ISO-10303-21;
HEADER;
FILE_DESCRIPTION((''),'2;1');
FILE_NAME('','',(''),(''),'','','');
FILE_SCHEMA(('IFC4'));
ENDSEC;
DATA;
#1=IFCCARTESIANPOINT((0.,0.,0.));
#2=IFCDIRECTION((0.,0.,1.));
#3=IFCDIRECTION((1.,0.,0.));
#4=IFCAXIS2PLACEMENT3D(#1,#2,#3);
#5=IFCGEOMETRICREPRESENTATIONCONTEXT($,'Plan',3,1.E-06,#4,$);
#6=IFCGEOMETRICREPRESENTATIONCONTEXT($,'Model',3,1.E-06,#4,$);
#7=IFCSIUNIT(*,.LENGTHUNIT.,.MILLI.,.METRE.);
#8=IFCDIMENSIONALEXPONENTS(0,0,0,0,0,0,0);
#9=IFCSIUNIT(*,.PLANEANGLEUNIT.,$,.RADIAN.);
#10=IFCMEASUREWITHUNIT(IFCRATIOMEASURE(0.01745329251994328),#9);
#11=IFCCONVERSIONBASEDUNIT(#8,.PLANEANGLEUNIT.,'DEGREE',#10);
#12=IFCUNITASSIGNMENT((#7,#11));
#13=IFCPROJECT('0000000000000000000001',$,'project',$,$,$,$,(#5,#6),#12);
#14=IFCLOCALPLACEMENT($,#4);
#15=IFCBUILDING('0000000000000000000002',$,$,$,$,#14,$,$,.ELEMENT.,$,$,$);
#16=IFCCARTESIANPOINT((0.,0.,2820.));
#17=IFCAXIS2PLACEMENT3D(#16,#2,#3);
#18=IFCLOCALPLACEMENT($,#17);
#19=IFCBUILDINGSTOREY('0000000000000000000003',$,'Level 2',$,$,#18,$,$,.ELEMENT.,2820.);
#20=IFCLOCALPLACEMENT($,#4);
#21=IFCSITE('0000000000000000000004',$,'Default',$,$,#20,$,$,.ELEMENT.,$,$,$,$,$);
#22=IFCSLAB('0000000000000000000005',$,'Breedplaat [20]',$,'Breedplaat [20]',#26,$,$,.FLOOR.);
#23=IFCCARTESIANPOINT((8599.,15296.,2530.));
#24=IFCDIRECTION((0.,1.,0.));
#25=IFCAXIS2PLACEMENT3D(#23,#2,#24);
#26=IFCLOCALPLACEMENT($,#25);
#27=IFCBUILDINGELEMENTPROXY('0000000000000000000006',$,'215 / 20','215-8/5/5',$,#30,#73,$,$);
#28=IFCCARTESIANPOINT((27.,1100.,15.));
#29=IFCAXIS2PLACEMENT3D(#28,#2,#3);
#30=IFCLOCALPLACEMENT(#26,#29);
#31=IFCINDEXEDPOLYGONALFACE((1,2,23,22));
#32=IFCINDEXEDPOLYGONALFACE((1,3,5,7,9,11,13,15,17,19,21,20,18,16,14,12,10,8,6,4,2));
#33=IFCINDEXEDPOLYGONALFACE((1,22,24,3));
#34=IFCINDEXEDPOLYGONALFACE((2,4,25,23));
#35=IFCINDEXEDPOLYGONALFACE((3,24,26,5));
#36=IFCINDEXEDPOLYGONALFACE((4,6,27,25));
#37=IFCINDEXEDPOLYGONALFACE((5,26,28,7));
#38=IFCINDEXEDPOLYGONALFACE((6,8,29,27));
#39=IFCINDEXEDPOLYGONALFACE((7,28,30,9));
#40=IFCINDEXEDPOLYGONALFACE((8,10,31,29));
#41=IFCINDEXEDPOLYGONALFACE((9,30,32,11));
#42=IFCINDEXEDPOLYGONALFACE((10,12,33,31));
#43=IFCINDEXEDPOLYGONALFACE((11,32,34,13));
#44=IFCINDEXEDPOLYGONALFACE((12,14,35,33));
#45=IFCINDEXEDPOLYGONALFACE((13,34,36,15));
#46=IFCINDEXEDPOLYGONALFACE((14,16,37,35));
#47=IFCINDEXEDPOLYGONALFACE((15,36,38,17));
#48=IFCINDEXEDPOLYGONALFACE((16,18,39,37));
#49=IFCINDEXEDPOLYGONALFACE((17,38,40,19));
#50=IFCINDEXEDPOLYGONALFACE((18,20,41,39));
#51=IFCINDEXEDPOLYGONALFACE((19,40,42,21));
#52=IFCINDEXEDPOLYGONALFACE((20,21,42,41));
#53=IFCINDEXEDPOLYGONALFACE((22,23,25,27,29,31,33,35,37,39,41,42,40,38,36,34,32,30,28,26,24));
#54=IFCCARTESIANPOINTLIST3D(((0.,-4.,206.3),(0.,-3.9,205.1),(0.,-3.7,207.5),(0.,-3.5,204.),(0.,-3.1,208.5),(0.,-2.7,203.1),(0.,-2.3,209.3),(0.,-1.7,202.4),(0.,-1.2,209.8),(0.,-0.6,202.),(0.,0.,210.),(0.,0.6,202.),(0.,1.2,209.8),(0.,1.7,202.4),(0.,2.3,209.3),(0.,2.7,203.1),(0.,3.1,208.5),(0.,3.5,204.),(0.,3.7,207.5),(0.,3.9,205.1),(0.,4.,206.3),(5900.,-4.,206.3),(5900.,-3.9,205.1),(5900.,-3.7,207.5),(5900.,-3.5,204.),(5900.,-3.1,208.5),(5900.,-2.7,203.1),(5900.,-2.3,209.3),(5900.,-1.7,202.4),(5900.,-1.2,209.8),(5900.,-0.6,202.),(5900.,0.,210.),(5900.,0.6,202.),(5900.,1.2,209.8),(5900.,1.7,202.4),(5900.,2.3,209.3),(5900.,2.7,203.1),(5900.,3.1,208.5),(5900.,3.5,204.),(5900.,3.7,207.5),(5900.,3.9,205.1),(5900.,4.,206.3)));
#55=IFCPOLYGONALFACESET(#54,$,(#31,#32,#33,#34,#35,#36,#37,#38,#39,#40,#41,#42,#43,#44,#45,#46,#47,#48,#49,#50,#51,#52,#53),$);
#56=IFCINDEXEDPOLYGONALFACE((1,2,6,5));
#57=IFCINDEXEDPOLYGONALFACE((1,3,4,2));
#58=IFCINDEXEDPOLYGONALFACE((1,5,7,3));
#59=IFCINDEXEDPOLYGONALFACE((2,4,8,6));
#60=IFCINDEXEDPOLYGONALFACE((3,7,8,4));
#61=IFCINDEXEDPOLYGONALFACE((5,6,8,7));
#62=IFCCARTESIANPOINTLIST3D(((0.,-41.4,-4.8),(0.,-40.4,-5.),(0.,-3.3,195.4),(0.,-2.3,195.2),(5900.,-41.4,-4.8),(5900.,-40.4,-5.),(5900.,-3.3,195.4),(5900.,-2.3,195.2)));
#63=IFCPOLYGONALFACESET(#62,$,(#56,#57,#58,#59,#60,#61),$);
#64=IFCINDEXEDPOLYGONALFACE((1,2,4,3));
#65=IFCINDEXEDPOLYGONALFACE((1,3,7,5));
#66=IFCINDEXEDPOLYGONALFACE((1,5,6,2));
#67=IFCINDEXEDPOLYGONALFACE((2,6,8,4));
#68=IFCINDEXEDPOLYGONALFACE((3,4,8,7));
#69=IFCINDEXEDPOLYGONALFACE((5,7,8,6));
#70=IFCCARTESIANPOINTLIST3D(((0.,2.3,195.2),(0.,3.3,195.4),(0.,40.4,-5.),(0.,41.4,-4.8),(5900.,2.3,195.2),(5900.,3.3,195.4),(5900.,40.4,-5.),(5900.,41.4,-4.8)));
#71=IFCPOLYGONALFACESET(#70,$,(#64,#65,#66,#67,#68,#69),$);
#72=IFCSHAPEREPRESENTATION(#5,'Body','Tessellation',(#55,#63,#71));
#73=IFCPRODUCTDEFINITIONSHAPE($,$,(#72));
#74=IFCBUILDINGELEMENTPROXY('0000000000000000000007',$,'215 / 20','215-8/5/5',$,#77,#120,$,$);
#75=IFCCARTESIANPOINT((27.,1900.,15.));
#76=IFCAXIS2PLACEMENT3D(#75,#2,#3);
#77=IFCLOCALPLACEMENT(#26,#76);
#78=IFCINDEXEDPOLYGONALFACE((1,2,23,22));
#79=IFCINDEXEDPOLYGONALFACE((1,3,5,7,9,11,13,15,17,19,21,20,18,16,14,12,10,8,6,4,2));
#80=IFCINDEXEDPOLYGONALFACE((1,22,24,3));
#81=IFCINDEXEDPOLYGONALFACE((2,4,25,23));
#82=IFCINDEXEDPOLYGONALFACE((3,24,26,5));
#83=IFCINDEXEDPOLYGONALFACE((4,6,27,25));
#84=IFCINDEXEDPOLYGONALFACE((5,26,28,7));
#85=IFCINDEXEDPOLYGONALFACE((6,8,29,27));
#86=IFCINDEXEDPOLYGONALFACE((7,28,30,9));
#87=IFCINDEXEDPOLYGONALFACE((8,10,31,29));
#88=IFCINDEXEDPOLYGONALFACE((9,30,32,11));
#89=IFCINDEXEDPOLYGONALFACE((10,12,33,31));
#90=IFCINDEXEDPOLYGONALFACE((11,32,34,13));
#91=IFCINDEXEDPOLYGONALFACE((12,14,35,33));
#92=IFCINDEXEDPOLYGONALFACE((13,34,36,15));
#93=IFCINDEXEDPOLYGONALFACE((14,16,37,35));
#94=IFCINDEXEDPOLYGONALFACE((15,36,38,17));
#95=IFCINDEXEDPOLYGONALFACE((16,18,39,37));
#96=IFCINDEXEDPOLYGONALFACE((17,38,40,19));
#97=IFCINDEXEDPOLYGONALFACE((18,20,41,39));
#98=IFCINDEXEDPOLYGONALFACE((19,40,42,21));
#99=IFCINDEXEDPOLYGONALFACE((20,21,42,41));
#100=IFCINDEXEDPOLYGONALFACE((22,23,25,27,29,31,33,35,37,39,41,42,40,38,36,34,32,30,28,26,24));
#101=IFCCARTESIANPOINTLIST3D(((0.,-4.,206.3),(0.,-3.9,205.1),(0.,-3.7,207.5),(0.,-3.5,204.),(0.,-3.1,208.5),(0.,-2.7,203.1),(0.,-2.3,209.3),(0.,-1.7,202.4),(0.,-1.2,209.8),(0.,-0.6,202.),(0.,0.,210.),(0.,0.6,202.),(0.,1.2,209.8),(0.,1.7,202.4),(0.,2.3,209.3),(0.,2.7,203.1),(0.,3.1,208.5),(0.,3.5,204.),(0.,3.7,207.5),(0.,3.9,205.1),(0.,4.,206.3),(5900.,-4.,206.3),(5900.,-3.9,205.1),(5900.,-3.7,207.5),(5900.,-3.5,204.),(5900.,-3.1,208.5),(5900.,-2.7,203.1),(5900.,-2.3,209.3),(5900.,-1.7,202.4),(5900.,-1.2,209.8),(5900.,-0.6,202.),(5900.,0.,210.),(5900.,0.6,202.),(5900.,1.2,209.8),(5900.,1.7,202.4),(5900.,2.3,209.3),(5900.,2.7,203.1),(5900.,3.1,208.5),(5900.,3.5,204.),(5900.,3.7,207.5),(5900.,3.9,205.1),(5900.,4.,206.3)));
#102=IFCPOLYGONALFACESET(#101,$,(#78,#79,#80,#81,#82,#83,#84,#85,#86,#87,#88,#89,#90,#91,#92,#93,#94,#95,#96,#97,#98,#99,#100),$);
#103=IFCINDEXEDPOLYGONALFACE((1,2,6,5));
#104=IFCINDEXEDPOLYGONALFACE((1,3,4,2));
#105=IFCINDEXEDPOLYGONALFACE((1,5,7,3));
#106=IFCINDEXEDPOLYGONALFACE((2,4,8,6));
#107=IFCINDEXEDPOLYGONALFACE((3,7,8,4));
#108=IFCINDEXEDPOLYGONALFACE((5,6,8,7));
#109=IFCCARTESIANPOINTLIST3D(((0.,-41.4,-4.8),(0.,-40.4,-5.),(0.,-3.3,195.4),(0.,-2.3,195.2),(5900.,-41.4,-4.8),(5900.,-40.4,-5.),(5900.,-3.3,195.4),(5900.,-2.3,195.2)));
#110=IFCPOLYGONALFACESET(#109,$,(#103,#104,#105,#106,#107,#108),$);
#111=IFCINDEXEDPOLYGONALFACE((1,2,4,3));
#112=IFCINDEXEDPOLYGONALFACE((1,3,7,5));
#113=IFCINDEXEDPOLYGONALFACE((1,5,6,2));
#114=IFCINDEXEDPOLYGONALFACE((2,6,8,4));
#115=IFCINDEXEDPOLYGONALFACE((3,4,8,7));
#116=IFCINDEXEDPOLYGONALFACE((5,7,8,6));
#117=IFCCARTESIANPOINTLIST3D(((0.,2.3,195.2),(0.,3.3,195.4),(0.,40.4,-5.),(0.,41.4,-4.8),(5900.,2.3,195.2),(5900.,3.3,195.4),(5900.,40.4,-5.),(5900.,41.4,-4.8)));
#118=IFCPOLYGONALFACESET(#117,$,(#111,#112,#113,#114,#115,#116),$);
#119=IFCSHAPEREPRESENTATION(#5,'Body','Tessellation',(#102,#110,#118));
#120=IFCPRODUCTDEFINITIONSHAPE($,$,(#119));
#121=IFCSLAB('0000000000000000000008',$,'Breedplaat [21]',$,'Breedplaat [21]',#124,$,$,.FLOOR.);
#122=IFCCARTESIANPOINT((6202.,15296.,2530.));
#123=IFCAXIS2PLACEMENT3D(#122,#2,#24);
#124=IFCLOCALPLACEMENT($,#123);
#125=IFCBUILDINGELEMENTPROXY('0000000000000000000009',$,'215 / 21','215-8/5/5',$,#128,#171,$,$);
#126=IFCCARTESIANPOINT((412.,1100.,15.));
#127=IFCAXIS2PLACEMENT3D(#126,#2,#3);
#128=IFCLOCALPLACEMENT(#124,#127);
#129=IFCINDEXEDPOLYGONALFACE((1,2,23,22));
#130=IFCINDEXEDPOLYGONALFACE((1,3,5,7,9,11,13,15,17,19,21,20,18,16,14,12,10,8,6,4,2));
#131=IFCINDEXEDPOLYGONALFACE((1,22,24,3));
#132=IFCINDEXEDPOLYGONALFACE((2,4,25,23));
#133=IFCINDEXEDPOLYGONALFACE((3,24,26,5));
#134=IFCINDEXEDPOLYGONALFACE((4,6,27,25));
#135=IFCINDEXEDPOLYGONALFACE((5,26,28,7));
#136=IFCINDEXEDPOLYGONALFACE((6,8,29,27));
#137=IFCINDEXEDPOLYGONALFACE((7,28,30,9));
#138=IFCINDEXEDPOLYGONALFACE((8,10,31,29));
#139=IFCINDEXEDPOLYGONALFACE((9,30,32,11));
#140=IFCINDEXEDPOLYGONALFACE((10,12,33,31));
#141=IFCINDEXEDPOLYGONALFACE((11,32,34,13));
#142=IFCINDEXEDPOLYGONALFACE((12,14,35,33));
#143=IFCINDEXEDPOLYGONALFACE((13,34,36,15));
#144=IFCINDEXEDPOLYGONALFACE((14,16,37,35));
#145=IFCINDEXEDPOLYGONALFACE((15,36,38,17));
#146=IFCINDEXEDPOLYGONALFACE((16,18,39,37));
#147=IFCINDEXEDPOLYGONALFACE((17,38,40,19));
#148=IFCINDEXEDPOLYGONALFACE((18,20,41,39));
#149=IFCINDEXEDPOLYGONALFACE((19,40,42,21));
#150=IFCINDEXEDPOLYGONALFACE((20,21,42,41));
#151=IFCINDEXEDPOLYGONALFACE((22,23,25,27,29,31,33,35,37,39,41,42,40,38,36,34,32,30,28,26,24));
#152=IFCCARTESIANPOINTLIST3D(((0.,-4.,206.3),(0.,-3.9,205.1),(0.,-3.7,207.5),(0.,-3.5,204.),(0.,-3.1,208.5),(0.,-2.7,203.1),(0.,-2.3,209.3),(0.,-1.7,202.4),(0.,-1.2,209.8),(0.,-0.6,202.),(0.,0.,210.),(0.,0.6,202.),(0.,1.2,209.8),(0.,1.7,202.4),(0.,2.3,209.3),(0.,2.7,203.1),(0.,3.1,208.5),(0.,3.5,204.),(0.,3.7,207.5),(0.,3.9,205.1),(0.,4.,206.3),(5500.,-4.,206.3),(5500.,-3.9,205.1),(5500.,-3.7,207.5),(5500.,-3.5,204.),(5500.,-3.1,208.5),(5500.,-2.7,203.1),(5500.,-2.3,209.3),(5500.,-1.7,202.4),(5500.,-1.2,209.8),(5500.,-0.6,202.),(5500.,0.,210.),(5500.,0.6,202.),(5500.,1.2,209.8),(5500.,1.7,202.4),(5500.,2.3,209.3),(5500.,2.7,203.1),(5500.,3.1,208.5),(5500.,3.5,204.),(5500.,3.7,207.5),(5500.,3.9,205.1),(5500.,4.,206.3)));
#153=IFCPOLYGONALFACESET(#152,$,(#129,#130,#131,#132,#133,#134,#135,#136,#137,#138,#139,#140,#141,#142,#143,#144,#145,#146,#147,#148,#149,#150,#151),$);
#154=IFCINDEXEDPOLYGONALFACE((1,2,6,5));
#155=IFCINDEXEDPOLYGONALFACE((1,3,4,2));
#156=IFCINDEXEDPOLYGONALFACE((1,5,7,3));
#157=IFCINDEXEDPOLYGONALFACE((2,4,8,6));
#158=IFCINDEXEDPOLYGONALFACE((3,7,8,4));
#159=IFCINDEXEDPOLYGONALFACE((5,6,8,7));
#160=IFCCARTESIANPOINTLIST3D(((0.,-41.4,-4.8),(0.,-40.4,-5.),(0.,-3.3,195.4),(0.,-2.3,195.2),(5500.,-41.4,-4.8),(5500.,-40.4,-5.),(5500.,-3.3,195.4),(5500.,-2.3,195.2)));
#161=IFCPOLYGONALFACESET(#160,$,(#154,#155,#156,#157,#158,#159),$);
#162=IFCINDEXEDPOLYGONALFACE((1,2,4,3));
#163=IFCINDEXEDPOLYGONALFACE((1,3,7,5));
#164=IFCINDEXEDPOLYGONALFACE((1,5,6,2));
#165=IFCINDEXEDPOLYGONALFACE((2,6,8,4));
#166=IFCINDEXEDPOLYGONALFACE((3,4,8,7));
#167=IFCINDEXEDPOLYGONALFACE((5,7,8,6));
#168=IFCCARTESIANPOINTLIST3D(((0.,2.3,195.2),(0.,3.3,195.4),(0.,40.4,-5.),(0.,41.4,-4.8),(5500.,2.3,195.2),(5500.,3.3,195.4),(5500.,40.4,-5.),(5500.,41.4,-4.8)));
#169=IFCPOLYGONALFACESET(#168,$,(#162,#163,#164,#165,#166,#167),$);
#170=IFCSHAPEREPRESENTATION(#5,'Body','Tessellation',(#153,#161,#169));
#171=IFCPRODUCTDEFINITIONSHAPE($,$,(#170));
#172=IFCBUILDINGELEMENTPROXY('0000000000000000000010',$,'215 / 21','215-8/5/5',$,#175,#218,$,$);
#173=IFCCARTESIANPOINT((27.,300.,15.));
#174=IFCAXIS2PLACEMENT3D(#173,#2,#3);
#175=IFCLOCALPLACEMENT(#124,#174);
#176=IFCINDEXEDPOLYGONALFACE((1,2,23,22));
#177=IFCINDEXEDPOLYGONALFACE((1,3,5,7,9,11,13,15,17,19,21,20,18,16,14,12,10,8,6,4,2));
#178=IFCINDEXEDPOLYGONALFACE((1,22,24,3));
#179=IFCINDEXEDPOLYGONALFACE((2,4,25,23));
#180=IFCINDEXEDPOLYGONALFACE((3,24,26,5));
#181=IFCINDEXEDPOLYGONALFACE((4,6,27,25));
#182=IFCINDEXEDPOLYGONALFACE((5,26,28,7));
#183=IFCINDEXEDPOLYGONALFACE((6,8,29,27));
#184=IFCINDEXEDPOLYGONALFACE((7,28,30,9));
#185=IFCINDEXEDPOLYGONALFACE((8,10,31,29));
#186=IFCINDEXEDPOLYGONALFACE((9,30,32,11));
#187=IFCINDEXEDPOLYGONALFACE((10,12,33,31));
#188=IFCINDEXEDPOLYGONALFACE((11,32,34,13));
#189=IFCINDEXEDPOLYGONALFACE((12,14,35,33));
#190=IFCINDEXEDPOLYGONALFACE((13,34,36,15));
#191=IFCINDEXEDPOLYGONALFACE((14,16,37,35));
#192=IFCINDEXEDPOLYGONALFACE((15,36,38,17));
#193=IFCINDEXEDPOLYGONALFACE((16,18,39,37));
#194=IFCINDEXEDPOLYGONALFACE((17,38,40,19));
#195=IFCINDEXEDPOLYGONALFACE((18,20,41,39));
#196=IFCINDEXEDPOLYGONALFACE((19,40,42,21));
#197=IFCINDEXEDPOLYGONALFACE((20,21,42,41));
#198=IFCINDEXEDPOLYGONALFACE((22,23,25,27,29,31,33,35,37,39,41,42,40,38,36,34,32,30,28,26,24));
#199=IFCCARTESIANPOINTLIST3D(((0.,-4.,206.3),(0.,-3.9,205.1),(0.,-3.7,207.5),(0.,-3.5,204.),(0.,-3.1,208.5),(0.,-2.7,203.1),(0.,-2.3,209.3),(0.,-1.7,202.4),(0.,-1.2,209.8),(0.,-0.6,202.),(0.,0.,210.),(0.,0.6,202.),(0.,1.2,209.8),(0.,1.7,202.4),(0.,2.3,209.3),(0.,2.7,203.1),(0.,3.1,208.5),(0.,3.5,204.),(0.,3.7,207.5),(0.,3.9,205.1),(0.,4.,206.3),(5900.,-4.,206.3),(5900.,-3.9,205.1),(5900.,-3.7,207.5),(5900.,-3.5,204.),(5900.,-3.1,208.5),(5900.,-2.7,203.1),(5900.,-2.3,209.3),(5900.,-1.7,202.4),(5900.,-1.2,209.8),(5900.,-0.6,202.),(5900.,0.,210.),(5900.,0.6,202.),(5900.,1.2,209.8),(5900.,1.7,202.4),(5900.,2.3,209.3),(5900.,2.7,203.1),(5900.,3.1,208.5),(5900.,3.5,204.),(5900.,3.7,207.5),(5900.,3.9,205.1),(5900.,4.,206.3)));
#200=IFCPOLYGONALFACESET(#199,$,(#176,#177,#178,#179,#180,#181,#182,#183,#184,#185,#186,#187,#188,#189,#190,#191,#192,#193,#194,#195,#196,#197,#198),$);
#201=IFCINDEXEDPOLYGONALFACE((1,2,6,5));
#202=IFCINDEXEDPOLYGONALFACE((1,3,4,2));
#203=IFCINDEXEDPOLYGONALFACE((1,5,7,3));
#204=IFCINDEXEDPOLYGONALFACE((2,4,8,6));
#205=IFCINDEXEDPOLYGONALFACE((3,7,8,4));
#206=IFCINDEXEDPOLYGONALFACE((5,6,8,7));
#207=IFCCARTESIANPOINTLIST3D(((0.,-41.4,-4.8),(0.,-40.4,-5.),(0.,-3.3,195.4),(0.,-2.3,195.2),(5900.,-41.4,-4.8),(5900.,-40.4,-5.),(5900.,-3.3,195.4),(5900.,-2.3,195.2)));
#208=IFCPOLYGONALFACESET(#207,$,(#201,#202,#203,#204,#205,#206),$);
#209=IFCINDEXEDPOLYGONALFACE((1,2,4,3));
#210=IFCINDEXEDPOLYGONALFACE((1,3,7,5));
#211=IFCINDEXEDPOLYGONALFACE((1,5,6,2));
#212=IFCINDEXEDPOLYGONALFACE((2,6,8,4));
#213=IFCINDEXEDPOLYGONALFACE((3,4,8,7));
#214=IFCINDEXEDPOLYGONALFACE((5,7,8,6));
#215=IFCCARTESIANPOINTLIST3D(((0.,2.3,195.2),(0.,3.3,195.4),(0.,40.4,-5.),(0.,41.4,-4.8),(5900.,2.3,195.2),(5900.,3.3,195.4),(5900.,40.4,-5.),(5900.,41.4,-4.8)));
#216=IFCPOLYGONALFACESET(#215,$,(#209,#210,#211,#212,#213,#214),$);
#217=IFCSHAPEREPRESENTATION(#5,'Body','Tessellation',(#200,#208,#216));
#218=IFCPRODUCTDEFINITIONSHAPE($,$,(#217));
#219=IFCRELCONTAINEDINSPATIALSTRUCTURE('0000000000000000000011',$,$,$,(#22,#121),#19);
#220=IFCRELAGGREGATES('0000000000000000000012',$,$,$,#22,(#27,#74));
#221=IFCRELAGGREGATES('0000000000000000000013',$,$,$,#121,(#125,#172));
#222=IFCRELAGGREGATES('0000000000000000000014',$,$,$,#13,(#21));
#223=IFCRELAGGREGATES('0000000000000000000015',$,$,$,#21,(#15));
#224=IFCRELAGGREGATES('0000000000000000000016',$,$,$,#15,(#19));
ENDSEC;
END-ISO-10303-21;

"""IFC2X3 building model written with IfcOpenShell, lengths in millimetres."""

from ifc_helpers import new_model, entity, si_unit, converted_unit, frame, origin_with_axes, origin_2d_with_axis, place, context, project, spatial, rectangle, circle, extrude, element, aggregate, save


model = new_model("IFC2X3")

# Units and contexts
plan_context = context("Plan", 3, precision=1e-06, world=origin_with_axes())
model_context = context("Model", 3, precision=1e-06, world=origin_with_axes())
ifc_project = project(units=[si_unit("LENGTHUNIT", "METRE", prefix="MILLI"), converted_unit("PLANEANGLEUNIT", "DEGREE", entity("IfcRatioMeasure", 0.01745329251994328), si_unit("PLANEANGLEUNIT", "RADIAN"), dimensions=[0, 0, 0, 0, 0, 0, 0])], contexts=[plan_context, model_context])

# Site, building, storey
site_placement = place(None, origin_with_axes())
site = spatial("IfcSite", under=ifc_project, at=site_placement, Name="Default", CompositionType="ELEMENT")
building_placement = place(None, origin_with_axes())
building = spatial("IfcBuilding", under=site, at=building_placement, CompositionType="ELEMENT")
storey_placement = place(None, frame((0.0, 0.0, 2820.0), z_axis=(0.0, 0.0, 1.0), x_axis=(1.0, 0.0, 0.0)))
storey = spatial("IfcBuildingStorey", under=building, at=storey_placement, Name="Level 2", CompositionType="ELEMENT", Elevation=2820.0)

# Slab, building element proxies
slab_1_placement = place(None, frame((8599.0, 15296.0, 2530.0), z_axis=(0.0, 0.0, 1.0), x_axis=(0.0, 1.0, 0.0)))
slab_1 = element("IfcSlab", 1, at=slab_1_placement, inside=storey, Name="Breedplaat [20]", ObjectType="Breedplaat [20]", PredefinedType="FLOOR")
proxy_1_placement = place(slab_1_placement, frame((27.0, 1100.0, 15.0), z_axis=(0.0, 0.0, 1.0), x_axis=(1.0, 0.0, 0.0)))
proxy_1 = element("IfcBuildingElementProxy", 2, at=proxy_1_placement, Name="215 / 20", Description="215-8/5/5", context=plan_context, shape_type="SweptSolid", body=[
    extrude(circle(Radius=4.0, at=origin_2d_with_axis()), frame((0.0, 0.0, 206.0), z_axis=(1.0, 0.0, 0.0), x_axis=(0.0, 0.0, 1.0)), (0.0, 0.0, 1.0), 5900.0),
    extrude(rectangle(XDim=203.8, YDim=1.0, at=origin_2d_with_axis()), frame((0.0, -21.9, 95.2), z_axis=(1.0, 0.0, 0.0), x_axis=(0.0, 0.187112, 0.982339)), (0.0, 0.0, 1.0), 5900.0),
    extrude(rectangle(XDim=203.8, YDim=1.0, at=origin_2d_with_axis()), frame((0.0, 21.9, 95.2), z_axis=(1.0, 0.0, 0.0), x_axis=(0.0, -0.187112, 0.982339)), (0.0, 0.0, 1.0), 5900.0),
])
proxy_2_placement = place(slab_1_placement, frame((27.0, 1900.0, 15.0), z_axis=(0.0, 0.0, 1.0), x_axis=(1.0, 0.0, 0.0)))
proxy_2 = element("IfcBuildingElementProxy", 3, at=proxy_2_placement, Name="215 / 20", Description="215-8/5/5", context=plan_context, shape_type="SweptSolid", body=[
    extrude(circle(Radius=4.0, at=origin_2d_with_axis()), frame((0.0, 0.0, 206.0), z_axis=(1.0, 0.0, 0.0), x_axis=(0.0, 0.0, 1.0)), (0.0, 0.0, 1.0), 5900.0),
    extrude(rectangle(XDim=203.8, YDim=1.0, at=origin_2d_with_axis()), frame((0.0, -21.9, 95.2), z_axis=(1.0, 0.0, 0.0), x_axis=(0.0, 0.187112, 0.982339)), (0.0, 0.0, 1.0), 5900.0),
    extrude(rectangle(XDim=203.8, YDim=1.0, at=origin_2d_with_axis()), frame((0.0, 21.9, 95.2), z_axis=(1.0, 0.0, 0.0), x_axis=(0.0, -0.187112, 0.982339)), (0.0, 0.0, 1.0), 5900.0),
])
aggregate(slab_1, [proxy_1, proxy_2])

# Slab, building element proxies
slab_2_placement = place(None, frame((6202.0, 15296.0, 2530.0), z_axis=(0.0, 0.0, 1.0), x_axis=(0.0, 1.0, 0.0)))
slab_2 = element("IfcSlab", 4, at=slab_2_placement, inside=storey, Name="Breedplaat [21]", ObjectType="Breedplaat [21]", PredefinedType="FLOOR")
proxy_3_placement = place(slab_2_placement, frame((412.0, 1100.0, 15.0), z_axis=(0.0, 0.0, 1.0), x_axis=(1.0, 0.0, 0.0)))
proxy_3 = element("IfcBuildingElementProxy", 5, at=proxy_3_placement, Name="215 / 21", Description="215-8/5/5", context=plan_context, shape_type="SweptSolid", body=[
    extrude(circle(Radius=4.0, at=origin_2d_with_axis()), frame((0.0, 0.0, 206.0), z_axis=(1.0, 0.0, 0.0), x_axis=(0.0, 0.0, 1.0)), (0.0, 0.0, 1.0), 5500.0),
    extrude(rectangle(XDim=203.8, YDim=1.0, at=origin_2d_with_axis()), frame((0.0, -21.9, 95.2), z_axis=(1.0, 0.0, 0.0), x_axis=(0.0, 0.187112, 0.982339)), (0.0, 0.0, 1.0), 5500.0),
    extrude(rectangle(XDim=203.8, YDim=1.0, at=origin_2d_with_axis()), frame((0.0, 21.9, 95.2), z_axis=(1.0, 0.0, 0.0), x_axis=(0.0, -0.187112, 0.982339)), (0.0, 0.0, 1.0), 5500.0),
])
proxy_4_placement = place(slab_2_placement, frame((27.0, 300.0, 15.0), z_axis=(0.0, 0.0, 1.0), x_axis=(1.0, 0.0, 0.0)))
proxy_4 = element("IfcBuildingElementProxy", 6, at=proxy_4_placement, Name="215 / 21", Description="215-8/5/5", context=plan_context, shape_type="SweptSolid", body=[
    extrude(circle(Radius=4.0, at=origin_2d_with_axis()), frame((0.0, 0.0, 206.0), z_axis=(1.0, 0.0, 0.0), x_axis=(0.0, 0.0, 1.0)), (0.0, 0.0, 1.0), 5900.0),
    extrude(rectangle(XDim=203.8, YDim=1.0, at=origin_2d_with_axis()), frame((0.0, -21.9, 95.2), z_axis=(1.0, 0.0, 0.0), x_axis=(0.0, 0.187112, 0.982339)), (0.0, 0.0, 1.0), 5900.0),
    extrude(rectangle(XDim=203.8, YDim=1.0, at=origin_2d_with_axis()), frame((0.0, 21.9, 95.2), z_axis=(1.0, 0.0, 0.0), x_axis=(0.0, -0.187112, 0.982339)), (0.0, 0.0, 1.0), 5900.0),
])
aggregate(slab_2, [proxy_3, proxy_4])

save(model, "model.ifc")
